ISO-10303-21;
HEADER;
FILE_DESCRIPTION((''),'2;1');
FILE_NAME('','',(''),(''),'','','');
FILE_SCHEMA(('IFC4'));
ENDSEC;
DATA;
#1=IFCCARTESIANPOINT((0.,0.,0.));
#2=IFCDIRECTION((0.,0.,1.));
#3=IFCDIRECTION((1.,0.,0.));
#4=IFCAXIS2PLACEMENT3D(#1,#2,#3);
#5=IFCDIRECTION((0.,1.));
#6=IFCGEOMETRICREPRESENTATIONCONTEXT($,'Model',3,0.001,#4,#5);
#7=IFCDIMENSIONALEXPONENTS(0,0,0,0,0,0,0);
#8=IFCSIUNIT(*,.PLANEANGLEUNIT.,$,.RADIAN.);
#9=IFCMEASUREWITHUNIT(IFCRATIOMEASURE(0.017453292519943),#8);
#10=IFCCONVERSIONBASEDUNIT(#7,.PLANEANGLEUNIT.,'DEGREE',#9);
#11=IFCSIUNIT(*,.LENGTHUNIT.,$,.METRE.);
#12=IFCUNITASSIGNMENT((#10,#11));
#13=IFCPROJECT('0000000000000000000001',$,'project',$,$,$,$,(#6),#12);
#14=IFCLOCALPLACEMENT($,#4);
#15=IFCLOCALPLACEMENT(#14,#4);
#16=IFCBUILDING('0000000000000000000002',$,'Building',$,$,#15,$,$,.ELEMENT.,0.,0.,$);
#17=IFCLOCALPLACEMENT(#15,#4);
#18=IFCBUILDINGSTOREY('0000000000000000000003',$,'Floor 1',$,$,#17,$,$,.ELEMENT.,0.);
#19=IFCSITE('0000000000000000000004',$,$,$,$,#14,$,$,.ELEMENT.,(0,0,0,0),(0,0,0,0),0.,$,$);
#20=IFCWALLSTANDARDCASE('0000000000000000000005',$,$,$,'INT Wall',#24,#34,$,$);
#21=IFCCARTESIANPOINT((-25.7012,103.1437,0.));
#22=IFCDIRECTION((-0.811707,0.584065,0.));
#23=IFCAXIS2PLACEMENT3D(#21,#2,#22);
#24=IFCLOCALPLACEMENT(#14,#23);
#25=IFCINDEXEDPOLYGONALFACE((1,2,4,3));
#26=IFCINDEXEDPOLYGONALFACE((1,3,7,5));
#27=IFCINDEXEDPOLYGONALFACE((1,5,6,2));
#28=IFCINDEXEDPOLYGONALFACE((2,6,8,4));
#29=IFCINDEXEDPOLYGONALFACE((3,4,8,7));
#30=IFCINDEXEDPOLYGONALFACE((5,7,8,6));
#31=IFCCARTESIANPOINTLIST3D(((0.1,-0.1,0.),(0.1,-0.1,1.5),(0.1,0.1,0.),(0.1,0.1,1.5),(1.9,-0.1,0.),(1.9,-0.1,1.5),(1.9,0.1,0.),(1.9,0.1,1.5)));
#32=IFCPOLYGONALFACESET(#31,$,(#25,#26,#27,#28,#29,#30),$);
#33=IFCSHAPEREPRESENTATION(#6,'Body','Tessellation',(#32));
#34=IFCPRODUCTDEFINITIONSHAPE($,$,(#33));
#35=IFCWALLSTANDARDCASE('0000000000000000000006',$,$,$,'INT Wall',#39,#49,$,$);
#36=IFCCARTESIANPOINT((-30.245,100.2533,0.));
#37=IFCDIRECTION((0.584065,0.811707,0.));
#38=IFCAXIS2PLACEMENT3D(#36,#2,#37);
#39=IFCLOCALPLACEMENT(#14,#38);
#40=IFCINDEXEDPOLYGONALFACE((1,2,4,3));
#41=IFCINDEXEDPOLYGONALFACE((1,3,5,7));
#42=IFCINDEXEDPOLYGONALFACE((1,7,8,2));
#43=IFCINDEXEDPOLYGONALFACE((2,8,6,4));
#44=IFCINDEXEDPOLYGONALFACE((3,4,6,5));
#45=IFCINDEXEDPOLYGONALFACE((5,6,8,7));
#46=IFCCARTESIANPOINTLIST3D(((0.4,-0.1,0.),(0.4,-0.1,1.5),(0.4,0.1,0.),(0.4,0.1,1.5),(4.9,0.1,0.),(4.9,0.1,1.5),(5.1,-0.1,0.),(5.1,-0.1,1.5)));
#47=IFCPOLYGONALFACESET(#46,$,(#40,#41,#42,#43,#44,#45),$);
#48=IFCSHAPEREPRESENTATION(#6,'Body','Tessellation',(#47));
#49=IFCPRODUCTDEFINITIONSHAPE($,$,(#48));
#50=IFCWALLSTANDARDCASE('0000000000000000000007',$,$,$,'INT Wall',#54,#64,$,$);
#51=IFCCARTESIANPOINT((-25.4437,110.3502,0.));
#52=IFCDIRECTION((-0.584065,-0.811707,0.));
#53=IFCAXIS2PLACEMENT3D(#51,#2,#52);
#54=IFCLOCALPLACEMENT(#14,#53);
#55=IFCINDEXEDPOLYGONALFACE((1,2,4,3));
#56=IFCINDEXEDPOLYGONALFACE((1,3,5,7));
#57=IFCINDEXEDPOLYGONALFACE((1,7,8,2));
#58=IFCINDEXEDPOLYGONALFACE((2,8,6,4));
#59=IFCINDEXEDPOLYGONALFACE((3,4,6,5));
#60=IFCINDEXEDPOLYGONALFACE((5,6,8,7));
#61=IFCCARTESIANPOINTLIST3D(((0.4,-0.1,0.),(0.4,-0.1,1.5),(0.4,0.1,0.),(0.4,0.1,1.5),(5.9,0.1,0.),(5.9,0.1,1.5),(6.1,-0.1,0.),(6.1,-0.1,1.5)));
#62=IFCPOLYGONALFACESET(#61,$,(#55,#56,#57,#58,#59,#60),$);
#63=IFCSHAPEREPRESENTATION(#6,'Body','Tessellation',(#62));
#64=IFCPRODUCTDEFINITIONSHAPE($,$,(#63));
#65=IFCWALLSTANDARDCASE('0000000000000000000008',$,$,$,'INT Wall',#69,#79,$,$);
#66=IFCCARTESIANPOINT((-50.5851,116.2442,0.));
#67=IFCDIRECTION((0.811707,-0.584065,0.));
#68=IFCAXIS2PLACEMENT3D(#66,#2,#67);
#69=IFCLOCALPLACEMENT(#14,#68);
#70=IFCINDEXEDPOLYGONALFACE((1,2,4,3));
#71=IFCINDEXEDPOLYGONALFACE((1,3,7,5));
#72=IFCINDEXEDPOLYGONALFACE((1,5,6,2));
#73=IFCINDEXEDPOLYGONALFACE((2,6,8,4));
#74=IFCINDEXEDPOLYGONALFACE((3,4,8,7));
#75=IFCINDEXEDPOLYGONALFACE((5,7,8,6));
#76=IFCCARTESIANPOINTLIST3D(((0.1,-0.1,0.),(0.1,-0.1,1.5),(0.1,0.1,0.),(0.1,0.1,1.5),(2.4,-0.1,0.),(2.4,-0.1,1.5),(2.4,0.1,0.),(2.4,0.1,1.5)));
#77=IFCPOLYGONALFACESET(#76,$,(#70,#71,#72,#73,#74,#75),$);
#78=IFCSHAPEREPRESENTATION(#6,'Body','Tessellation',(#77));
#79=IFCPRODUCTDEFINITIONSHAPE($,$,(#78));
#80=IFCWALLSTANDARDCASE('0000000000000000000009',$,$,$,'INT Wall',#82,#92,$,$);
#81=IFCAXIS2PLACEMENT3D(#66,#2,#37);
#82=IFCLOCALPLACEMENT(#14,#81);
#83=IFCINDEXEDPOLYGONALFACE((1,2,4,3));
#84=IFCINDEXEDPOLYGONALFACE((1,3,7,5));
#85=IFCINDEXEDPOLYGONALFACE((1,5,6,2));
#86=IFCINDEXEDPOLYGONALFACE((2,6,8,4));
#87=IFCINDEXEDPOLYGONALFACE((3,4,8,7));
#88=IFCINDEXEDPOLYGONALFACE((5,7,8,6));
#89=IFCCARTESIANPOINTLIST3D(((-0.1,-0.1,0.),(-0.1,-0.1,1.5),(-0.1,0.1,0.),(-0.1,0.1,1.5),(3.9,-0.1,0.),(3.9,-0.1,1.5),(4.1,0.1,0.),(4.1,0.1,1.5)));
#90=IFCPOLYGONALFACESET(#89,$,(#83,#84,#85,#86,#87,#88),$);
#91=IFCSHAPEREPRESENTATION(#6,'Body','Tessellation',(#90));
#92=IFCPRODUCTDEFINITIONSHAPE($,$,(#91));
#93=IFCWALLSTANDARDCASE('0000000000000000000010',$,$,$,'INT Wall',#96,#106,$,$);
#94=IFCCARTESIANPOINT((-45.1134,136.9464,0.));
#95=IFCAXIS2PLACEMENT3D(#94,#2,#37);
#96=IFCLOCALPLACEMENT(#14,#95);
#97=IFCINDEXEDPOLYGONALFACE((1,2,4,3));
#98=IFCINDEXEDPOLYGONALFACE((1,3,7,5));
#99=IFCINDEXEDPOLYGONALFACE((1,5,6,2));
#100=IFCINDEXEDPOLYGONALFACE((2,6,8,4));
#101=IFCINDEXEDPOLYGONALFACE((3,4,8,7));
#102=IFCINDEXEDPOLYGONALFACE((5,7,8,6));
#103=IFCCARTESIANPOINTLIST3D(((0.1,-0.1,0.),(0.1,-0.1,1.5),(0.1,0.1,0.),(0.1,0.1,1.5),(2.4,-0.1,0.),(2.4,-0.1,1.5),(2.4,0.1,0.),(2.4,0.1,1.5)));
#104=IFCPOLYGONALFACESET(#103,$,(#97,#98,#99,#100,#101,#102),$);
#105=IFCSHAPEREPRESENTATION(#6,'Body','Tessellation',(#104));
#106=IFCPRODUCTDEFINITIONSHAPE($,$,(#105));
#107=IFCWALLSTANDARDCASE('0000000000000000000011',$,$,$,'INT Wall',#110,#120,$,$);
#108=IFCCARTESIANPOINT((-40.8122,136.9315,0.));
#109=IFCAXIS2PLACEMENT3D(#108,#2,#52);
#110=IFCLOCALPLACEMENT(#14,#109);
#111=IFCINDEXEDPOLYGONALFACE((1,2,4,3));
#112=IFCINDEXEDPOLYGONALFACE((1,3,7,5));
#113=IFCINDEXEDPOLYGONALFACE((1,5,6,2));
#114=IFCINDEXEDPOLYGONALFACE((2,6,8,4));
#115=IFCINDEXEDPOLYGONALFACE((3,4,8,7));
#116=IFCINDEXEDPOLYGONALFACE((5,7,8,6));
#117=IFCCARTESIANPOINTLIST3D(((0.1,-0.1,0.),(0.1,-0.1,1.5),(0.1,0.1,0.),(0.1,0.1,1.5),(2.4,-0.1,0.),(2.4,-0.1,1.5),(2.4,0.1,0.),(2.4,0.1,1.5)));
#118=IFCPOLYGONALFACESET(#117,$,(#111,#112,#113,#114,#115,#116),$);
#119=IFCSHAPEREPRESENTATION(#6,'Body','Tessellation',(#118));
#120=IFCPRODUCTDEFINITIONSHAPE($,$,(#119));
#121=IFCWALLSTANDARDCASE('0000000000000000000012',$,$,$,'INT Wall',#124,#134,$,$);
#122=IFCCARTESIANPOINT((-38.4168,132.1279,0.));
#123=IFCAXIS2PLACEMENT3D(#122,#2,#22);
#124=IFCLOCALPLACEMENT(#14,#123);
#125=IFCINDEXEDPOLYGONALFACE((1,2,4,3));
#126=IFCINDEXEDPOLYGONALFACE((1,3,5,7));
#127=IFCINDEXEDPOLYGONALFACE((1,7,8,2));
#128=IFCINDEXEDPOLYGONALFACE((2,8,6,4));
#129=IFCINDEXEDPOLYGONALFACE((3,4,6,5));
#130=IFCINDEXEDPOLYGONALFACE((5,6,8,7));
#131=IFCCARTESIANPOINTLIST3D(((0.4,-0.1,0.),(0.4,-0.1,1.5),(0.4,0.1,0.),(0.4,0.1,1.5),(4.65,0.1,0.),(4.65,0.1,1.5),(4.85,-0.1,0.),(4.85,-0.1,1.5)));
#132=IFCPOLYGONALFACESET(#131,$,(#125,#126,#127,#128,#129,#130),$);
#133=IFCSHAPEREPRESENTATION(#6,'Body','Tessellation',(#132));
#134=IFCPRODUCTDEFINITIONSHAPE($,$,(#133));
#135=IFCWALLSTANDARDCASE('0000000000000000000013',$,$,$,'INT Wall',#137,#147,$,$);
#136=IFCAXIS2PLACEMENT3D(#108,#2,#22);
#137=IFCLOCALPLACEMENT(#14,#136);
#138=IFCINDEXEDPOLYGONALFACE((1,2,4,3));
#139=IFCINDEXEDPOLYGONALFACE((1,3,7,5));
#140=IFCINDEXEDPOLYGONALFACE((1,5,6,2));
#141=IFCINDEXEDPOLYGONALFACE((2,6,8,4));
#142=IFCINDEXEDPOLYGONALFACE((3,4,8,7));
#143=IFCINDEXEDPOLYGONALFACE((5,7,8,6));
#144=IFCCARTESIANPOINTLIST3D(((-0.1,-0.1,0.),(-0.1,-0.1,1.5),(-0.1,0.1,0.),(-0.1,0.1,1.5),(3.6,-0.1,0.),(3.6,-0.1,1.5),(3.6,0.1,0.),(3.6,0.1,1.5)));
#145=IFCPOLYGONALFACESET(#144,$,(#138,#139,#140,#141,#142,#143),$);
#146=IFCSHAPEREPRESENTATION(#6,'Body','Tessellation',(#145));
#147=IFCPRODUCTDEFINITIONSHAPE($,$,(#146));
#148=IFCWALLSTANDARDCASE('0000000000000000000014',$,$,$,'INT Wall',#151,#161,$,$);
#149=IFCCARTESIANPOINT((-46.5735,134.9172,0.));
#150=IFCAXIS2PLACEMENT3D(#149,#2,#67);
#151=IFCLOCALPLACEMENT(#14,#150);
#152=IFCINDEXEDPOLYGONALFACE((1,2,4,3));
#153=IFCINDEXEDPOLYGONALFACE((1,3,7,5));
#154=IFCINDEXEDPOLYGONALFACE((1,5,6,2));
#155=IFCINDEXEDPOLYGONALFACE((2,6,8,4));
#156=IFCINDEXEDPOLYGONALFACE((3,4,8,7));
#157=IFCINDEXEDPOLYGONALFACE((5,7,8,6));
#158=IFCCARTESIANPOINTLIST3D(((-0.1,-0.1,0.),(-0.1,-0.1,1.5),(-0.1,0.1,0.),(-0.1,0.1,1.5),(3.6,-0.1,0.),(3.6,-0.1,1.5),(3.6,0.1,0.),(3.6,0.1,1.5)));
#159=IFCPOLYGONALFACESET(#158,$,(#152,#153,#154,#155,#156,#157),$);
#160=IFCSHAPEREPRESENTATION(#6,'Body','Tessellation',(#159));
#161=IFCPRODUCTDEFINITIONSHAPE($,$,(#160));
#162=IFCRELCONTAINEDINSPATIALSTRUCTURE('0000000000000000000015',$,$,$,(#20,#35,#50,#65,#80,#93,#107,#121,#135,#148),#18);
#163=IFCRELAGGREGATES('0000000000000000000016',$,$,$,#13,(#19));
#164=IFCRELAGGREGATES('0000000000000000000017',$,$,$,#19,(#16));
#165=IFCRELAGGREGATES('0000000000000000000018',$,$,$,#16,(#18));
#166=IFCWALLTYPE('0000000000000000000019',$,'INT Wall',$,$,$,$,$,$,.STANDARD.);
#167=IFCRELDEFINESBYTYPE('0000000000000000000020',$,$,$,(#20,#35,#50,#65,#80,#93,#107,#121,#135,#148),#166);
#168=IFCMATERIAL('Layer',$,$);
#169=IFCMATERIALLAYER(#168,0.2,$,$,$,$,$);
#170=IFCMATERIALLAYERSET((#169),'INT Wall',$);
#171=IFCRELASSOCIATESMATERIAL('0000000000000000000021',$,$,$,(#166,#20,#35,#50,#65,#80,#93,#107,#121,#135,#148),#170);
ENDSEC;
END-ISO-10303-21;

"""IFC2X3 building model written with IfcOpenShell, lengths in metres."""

from ifc_helpers import new_model, entity, si_unit, converted_unit, direction, frame, origin_with_axes, place, context, project, spatial, polyline, outline, extrude, material, layer, layer_set, layer_usage, type_object, element, save


model = new_model("IFC2X3")

# Units and contexts
model_context = context("Model", 3, precision=0.001, world=origin_with_axes(), true_north=direction((0.0, 1.0)))
ifc_project = project(units=[converted_unit("PLANEANGLEUNIT", "DEGREE", entity("IfcRatioMeasure", 0.017453292519943), si_unit("PLANEANGLEUNIT", "RADIAN"), dimensions=[0, 0, 0, 0, 0, 0, 0]), si_unit("LENGTHUNIT", "METRE")], contexts=[model_context])

# Site, building, storey
site_placement = place(None, origin_with_axes())
site = spatial("IfcSite", under=ifc_project, at=site_placement, CompositionType="ELEMENT", RefLatitude=(0, 0, 0, 0), RefLongitude=(0, 0, 0, 0), RefElevation=0.0)
building_placement = place(site_placement, origin_with_axes())
building = spatial("IfcBuilding", under=site, at=building_placement, Name="Building", CompositionType="ELEMENT", ElevationOfRefHeight=0.0, ElevationOfTerrain=0.0)
storey_placement = place(building_placement, origin_with_axes())
storey = spatial("IfcBuildingStorey", under=building, at=storey_placement, Name="Floor 1", CompositionType="ELEMENT", Elevation=0.0)

# Walls
ifc_material_1 = material(Name="Layer")
ifc_layer_1 = layer(ifc_material_1, 0.2)
ifc_layer_set_1 = layer_set([ifc_layer_1], Name="INT Wall")
ifc_layer_usage_1 = layer_usage(ifc_layer_set_1, "AXIS2", "POSITIVE", -0.1)
wall_type_1 = type_object("IfcWallType", Name="INT Wall", PredefinedType="STANDARD", material=ifc_layer_set_1)
wall_1_placement = place(site_placement, frame((-25.7012, 103.1437, 0.0), z_axis=(0.0, 0.0, 1.0), x_axis=(-0.811707, 0.584065, 0.0)))
element("IfcWallStandardCase", 1, at=wall_1_placement, inside=storey, type_object=wall_type_1, material=ifc_layer_usage_1, ObjectType="INT Wall", context=model_context, shape_type="SweptSolid", body=[
    extrude(outline(polyline([(1.9, -0.1), (1.9, 0.1), (0.1, 0.1), (0.1, -0.1), (1.9, -0.1)])), origin_with_axes(), (0.0, 0.0, 1.0), 1.5),
])
wall_2_placement = place(site_placement, frame((-30.245, 100.2533, 0.0), z_axis=(0.0, 0.0, 1.0), x_axis=(0.584065, 0.811707, 0.0)))
element("IfcWallStandardCase", 2, at=wall_2_placement, inside=storey, type_object=wall_type_1, material=ifc_layer_usage_1, ObjectType="INT Wall", context=model_context, shape_type="SweptSolid", body=[
    extrude(outline(polyline([(0.4, -0.1), (0.4, 0.1), (4.9, 0.1), (5.1, -0.1), (0.4, -0.1)])), origin_with_axes(), (0.0, 0.0, 1.0), 1.5),
])
wall_3_placement = place(site_placement, frame((-25.4437, 110.3502, 0.0), z_axis=(0.0, 0.0, 1.0), x_axis=(-0.584065, -0.811707, 0.0)))
element("IfcWallStandardCase", 3, at=wall_3_placement, inside=storey, type_object=wall_type_1, material=ifc_layer_usage_1, ObjectType="INT Wall", context=model_context, shape_type="SweptSolid", body=[
    extrude(outline(polyline([(0.4, -0.1), (0.4, 0.1), (5.9, 0.1), (6.1, -0.1), (0.4, -0.1)])), origin_with_axes(), (0.0, 0.0, 1.0), 1.5),
])
wall_4_placement = place(site_placement, frame((-50.5851, 116.2442, 0.0), z_axis=(0.0, 0.0, 1.0), x_axis=(0.811707, -0.584065, 0.0)))
element("IfcWallStandardCase", 4, at=wall_4_placement, inside=storey, type_object=wall_type_1, material=ifc_layer_usage_1, ObjectType="INT Wall", context=model_context, shape_type="SweptSolid", body=[
    extrude(outline(polyline([(2.4, -0.1), (2.4, 0.1), (0.1, 0.1), (0.1, -0.1), (2.4, -0.1)])), origin_with_axes(), (0.0, 0.0, 1.0), 1.5),
])
wall_5_placement = place(site_placement, frame((-50.5851, 116.2442, 0.0), z_axis=(0.0, 0.0, 1.0), x_axis=(0.584065, 0.811707, 0.0)))
element("IfcWallStandardCase", 5, at=wall_5_placement, inside=storey, type_object=wall_type_1, material=ifc_layer_usage_1, ObjectType="INT Wall", context=model_context, shape_type="SweptSolid", body=[
    extrude(outline(polyline([(3.9, -0.1), (4.1, 0.1), (-0.1, 0.1), (-0.1, -0.1), (3.9, -0.1)])), origin_with_axes(), (0.0, 0.0, 1.0), 1.5),
])
wall_6_placement = place(site_placement, frame((-45.1134, 136.9464, 0.0), z_axis=(0.0, 0.0, 1.0), x_axis=(0.584065, 0.811707, 0.0)))
element("IfcWallStandardCase", 6, at=wall_6_placement, inside=storey, type_object=wall_type_1, material=ifc_layer_usage_1, ObjectType="INT Wall", context=model_context, shape_type="SweptSolid", body=[
    extrude(outline(polyline([(2.4, 0.1), (2.4, -0.1), (0.1, -0.1), (0.1, 0.1), (2.4, 0.1)])), origin_with_axes(), (0.0, 0.0, 1.0), 1.5),
])
wall_7_placement = place(site_placement, frame((-40.8122, 136.9315, 0.0), z_axis=(0.0, 0.0, 1.0), x_axis=(-0.584065, -0.811707, 0.0)))
element("IfcWallStandardCase", 7, at=wall_7_placement, inside=storey, type_object=wall_type_1, material=ifc_layer_usage_1, ObjectType="INT Wall", context=model_context, shape_type="SweptSolid", body=[
    extrude(outline(polyline([(2.4, -0.1), (2.4, 0.1), (0.1, 0.1), (0.1, -0.1), (2.4, -0.1)])), origin_with_axes(), (0.0, 0.0, 1.0), 1.5),
])
wall_8_placement = place(site_placement, frame((-38.4168, 132.1279, 0.0), z_axis=(0.0, 0.0, 1.0), x_axis=(-0.811707, 0.584065, 0.0)))
element("IfcWallStandardCase", 8, at=wall_8_placement, inside=storey, type_object=wall_type_1, material=ifc_layer_usage_1, ObjectType="INT Wall", context=model_context, shape_type="SweptSolid", body=[
    extrude(outline(polyline([(0.4, -0.1), (0.4, 0.1), (4.65, 0.1), (4.85, -0.1), (0.4, -0.1)])), origin_with_axes(), (0.0, 0.0, 1.0), 1.5),
])
wall_9_placement = place(site_placement, frame((-40.8122, 136.9315, 0.0), z_axis=(0.0, 0.0, 1.0), x_axis=(-0.811707, 0.584065, 0.0)))
element("IfcWallStandardCase", 9, at=wall_9_placement, inside=storey, type_object=wall_type_1, material=ifc_layer_usage_1, ObjectType="INT Wall", context=model_context, shape_type="SweptSolid", body=[
    extrude(outline(polyline([(3.6, -0.1), (3.6, 0.1), (-0.1, 0.1), (-0.1, -0.1), (3.6, -0.1)])), origin_with_axes(), (0.0, 0.0, 1.0), 1.5),
])
wall_10_placement = place(site_placement, frame((-46.5735, 134.9172, 0.0), z_axis=(0.0, 0.0, 1.0), x_axis=(0.811707, -0.584065, 0.0)))
element("IfcWallStandardCase", 10, at=wall_10_placement, inside=storey, type_object=wall_type_1, material=ifc_layer_usage_1, ObjectType="INT Wall", context=model_context, shape_type="SweptSolid", body=[
    extrude(outline(polyline([(3.6, -0.1), (3.6, 0.1), (-0.1, 0.1), (-0.1, -0.1), (3.6, -0.1)])), origin_with_axes(), (0.0, 0.0, 1.0), 1.5),
])

save(model, "model.ifc")
